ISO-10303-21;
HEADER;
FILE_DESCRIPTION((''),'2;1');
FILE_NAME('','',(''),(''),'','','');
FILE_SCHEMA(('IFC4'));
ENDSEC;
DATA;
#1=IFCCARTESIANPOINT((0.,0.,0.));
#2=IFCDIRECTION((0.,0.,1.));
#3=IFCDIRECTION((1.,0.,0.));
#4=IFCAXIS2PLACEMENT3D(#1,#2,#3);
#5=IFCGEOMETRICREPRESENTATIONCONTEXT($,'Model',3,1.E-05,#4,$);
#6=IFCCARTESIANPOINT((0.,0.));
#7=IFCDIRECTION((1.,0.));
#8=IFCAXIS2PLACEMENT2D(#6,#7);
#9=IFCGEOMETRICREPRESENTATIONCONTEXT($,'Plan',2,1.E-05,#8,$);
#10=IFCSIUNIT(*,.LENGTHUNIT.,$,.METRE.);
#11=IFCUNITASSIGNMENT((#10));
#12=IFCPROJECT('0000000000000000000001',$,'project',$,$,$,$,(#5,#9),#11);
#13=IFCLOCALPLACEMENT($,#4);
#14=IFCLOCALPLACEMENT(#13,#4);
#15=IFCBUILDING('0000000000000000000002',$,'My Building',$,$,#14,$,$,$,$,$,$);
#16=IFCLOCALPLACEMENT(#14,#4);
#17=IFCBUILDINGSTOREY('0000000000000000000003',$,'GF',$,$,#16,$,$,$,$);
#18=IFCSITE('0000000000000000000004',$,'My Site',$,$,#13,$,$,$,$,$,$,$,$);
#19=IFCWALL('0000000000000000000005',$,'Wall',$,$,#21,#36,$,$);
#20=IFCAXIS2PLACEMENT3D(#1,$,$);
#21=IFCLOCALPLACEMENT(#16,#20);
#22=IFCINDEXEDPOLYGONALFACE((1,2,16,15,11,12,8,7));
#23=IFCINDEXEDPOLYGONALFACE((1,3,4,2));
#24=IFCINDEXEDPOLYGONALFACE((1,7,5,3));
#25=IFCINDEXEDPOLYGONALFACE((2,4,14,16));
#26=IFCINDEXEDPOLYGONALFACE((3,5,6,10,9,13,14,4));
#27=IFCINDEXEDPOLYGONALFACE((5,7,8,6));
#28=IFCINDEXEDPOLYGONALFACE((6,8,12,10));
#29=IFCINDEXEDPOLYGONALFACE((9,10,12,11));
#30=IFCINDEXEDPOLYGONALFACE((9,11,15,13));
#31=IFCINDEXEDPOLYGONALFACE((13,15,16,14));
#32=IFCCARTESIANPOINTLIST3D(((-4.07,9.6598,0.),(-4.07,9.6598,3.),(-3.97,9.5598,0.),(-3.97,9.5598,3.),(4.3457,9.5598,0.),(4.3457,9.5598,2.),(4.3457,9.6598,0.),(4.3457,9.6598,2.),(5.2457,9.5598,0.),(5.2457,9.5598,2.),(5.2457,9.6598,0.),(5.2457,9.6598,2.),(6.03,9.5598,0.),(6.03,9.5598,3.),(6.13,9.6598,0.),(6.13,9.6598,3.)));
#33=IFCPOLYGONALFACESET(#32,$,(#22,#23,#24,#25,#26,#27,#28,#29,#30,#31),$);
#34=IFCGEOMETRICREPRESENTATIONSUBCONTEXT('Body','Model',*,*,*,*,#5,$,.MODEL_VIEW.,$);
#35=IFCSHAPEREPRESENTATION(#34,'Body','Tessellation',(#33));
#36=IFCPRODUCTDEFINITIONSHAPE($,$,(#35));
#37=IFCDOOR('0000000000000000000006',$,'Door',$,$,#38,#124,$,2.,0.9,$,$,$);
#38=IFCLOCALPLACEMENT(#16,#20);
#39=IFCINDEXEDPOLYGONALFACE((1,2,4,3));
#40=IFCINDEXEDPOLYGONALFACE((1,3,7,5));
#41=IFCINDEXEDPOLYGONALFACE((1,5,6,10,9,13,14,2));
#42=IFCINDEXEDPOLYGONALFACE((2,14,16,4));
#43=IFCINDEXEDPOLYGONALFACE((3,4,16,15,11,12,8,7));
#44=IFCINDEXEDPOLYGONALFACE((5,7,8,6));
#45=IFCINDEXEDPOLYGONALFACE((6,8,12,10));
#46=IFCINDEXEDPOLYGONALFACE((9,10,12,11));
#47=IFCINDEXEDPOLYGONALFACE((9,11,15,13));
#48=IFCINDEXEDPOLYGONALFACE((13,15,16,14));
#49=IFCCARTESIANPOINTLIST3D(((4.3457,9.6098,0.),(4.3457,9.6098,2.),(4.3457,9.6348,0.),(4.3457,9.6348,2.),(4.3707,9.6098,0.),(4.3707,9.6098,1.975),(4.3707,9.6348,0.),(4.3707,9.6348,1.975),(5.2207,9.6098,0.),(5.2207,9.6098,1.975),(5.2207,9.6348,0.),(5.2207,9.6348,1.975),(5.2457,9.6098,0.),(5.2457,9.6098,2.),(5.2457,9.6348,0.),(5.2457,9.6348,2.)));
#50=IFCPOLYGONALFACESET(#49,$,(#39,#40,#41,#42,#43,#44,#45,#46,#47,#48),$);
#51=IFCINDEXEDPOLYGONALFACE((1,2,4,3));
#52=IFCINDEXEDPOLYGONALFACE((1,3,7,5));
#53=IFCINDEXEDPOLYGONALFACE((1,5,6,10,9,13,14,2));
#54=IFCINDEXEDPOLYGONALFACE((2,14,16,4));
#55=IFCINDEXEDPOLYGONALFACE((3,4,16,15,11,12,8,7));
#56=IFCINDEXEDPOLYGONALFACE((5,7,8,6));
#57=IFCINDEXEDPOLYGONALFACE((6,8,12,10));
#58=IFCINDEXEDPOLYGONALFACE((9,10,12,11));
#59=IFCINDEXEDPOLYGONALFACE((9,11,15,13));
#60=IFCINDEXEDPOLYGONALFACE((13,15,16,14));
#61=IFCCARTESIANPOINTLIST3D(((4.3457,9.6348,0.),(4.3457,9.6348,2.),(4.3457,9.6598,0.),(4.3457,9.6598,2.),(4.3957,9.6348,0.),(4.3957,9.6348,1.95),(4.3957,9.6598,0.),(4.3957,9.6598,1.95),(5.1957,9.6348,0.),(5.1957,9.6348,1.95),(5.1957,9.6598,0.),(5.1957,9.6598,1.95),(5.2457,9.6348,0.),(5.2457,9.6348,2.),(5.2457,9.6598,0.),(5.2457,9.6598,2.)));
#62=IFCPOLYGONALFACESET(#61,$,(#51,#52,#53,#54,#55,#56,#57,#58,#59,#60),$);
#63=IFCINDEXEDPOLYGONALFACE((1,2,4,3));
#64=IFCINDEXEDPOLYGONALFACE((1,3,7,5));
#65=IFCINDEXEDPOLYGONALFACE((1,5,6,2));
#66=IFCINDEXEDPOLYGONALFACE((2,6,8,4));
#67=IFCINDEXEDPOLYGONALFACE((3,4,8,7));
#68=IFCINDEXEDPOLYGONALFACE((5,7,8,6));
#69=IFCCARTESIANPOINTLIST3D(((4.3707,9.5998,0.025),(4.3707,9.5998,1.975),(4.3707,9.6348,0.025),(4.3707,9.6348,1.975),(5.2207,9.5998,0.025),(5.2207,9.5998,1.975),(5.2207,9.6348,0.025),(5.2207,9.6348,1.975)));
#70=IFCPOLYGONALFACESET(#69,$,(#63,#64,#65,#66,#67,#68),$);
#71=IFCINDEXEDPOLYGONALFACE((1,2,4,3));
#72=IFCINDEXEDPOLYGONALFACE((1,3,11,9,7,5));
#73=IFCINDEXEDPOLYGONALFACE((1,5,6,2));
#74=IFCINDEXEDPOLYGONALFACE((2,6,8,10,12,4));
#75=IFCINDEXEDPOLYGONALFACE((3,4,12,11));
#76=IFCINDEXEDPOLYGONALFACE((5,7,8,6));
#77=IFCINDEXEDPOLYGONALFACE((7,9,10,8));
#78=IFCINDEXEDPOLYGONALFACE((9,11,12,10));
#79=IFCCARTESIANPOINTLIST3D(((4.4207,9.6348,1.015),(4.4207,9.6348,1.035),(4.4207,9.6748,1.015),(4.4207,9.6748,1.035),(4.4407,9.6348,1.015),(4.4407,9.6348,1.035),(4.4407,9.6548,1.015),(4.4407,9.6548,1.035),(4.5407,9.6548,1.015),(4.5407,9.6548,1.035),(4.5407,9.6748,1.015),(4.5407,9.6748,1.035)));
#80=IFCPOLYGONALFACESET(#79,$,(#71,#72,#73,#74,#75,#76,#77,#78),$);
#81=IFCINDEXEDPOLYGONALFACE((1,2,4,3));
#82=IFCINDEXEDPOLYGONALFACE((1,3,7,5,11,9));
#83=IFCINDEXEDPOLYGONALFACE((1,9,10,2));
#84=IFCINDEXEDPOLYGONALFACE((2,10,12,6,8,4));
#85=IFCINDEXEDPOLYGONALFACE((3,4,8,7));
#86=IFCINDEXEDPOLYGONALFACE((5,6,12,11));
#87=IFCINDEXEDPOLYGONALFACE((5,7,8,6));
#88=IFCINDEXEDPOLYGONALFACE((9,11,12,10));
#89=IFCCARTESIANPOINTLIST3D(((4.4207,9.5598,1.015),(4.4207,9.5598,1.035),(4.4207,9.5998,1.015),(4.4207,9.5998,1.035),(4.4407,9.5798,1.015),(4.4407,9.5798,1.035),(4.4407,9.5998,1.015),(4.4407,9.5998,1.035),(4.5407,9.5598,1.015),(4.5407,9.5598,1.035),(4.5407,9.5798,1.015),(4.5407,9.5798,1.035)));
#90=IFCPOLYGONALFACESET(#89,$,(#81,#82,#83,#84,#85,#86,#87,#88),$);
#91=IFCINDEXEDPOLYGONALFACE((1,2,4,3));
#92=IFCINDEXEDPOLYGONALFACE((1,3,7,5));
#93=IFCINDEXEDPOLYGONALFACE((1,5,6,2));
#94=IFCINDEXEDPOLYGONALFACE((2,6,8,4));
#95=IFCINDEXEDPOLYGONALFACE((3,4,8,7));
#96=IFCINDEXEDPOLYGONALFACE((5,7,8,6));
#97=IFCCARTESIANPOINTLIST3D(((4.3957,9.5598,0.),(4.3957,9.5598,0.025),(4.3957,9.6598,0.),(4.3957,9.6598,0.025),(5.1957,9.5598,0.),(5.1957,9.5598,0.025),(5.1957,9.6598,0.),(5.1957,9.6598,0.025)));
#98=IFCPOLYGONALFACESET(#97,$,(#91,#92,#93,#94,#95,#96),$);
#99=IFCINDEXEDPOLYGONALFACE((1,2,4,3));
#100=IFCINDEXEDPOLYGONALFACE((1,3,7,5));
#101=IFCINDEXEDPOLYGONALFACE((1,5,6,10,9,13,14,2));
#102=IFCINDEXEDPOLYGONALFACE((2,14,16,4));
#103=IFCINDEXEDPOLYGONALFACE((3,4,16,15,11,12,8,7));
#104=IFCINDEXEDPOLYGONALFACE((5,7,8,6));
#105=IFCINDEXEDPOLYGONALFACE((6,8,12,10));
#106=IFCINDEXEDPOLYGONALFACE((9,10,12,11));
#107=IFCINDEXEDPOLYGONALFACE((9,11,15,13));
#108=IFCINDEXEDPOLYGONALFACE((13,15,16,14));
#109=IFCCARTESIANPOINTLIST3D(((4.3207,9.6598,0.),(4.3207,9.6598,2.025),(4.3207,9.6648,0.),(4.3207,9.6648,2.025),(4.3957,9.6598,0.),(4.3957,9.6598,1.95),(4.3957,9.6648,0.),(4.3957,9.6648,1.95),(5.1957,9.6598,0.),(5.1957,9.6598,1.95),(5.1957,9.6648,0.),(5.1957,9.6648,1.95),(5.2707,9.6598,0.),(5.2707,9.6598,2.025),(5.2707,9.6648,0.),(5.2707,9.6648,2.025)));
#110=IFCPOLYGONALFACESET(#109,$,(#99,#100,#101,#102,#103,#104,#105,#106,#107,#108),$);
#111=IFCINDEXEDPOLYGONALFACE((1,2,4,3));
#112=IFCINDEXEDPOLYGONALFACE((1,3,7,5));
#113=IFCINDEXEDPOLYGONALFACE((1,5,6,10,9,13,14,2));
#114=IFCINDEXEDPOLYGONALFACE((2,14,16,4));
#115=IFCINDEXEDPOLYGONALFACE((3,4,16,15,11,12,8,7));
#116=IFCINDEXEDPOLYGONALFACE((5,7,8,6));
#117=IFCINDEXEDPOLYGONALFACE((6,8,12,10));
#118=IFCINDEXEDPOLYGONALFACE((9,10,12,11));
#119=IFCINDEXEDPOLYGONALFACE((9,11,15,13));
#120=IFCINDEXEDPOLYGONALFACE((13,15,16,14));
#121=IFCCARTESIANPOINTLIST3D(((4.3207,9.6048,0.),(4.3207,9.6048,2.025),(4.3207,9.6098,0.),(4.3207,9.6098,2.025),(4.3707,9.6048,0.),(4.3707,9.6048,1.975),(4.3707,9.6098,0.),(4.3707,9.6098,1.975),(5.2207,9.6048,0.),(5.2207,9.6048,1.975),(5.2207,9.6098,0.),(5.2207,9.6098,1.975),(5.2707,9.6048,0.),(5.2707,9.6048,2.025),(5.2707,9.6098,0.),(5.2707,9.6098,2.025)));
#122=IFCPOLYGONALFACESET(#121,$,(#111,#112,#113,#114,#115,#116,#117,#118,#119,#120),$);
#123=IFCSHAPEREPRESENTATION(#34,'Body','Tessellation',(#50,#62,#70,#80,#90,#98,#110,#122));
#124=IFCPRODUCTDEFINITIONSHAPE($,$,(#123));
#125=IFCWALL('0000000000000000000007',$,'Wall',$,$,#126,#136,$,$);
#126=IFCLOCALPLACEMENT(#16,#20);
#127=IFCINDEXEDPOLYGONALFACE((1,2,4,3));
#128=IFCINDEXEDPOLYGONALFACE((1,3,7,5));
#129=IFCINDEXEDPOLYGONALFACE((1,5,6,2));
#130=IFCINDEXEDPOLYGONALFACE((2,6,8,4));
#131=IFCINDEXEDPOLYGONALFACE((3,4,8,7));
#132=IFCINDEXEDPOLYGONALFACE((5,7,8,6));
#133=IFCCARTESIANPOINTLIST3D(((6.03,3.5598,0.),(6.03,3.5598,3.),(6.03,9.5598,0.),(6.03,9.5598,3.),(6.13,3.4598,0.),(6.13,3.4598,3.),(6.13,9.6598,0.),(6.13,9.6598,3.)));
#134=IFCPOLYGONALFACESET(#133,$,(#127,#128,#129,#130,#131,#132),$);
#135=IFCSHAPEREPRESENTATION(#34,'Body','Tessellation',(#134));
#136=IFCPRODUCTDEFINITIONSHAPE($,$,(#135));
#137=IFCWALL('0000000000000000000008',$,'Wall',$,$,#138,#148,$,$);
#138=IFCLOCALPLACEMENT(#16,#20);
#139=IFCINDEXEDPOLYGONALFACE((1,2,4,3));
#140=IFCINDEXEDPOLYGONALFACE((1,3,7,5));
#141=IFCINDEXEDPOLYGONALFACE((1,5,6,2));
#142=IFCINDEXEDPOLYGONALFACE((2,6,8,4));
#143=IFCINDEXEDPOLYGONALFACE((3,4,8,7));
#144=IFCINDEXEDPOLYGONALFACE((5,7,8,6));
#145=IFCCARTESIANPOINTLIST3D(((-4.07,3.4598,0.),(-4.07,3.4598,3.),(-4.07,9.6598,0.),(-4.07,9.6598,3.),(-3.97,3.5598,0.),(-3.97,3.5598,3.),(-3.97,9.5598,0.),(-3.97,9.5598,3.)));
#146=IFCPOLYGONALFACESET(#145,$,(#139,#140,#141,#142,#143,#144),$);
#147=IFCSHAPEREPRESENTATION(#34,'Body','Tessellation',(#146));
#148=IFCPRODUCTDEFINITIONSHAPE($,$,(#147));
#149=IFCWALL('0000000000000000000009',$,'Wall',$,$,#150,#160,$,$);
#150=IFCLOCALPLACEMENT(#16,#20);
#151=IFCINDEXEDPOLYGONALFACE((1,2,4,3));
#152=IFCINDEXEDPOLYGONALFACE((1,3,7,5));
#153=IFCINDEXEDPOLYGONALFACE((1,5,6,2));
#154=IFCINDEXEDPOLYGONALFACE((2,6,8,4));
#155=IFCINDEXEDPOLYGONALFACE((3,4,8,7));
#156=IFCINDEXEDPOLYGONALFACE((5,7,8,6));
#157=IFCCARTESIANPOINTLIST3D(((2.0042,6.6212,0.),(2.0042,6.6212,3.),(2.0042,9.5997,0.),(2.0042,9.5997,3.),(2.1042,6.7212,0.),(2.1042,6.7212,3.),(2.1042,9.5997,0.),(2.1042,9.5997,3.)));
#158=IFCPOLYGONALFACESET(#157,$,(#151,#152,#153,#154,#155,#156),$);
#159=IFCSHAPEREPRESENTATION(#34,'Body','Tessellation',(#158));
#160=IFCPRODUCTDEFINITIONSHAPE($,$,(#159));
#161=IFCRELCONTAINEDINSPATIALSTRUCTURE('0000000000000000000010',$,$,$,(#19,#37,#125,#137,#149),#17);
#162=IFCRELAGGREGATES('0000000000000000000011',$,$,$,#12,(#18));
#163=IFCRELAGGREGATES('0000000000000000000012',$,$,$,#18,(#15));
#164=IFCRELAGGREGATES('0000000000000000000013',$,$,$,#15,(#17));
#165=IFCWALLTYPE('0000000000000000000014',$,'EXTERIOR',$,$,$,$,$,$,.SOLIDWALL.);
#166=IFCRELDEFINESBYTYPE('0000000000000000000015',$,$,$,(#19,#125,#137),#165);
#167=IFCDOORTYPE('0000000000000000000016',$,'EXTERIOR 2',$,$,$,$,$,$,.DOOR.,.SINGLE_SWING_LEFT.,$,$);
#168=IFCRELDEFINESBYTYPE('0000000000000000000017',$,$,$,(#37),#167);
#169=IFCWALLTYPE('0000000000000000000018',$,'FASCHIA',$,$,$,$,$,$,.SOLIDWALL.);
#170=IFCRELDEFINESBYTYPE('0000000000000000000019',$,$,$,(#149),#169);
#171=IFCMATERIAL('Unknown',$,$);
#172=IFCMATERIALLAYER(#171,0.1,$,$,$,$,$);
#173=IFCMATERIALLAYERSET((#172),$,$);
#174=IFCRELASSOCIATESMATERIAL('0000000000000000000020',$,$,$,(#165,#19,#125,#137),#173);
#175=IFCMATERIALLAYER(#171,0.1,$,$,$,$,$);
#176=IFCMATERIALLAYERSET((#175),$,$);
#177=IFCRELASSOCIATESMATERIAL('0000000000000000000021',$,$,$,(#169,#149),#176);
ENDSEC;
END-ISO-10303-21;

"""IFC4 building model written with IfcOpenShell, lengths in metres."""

from ifc_helpers import new_model, entity, si_unit, frame, origin_with_axes, origin_2d_with_axis, place, context, subcontext, project, spatial, line, indexed_curve, outline, extrude, shape, source, transform, mapped, material, layer, layer_set, layer_usage, type_object, type_shapes, element, fill, save


model = new_model("IFC4")

# Units and contexts
model_context = context("Model", 3, precision=1e-05, world=origin_with_axes())
plan_context = context("Plan", 2, precision=1e-05, world=origin_2d_with_axis())
body_context_1 = subcontext(model_context, "Body", "Model", "MODEL_VIEW")
body_context_2 = subcontext(plan_context, "Body", "Plan", "PLAN_VIEW")
ifc_project = project(units=[si_unit("LENGTHUNIT", "METRE")], contexts=[model_context, plan_context])

# Site, building, storey
site_placement = place(None, origin_with_axes())
site = spatial("IfcSite", under=ifc_project, at=site_placement, Name="My Site")
building_placement = place(site_placement, origin_with_axes())
building = spatial("IfcBuilding", under=site, at=building_placement, Name="My Building")
storey_placement = place(building_placement, origin_with_axes())
storey = spatial("IfcBuildingStorey", under=building, at=storey_placement, Name="GF")

# Shared definitions
ifc_material = material(Name="Unknown")

# Wall, opening, door
ifc_layer_1 = layer(ifc_material, 0.1)
ifc_layer_set_1 = layer_set([ifc_layer_1])
ifc_layer_usage_1 = layer_usage(ifc_layer_set_1, "AXIS2", "POSITIVE", 0.0)
wall_type_1 = type_object("IfcWallType", Name="EXTERIOR", PredefinedType="SOLIDWALL", material=ifc_layer_set_1)
wall_1_placement = place(storey_placement, frame((-3.97, 9.5598, 0.0), z_axis=(0.0, 0.0, 1.0), x_axis=(1.0, 0.0, 0.0)))
wall_1 = element("IfcWall", 1, at=wall_1_placement, inside=storey, type_object=wall_type_1, material=ifc_layer_usage_1, Name="Wall", context=body_context_1, shape_type="SweptSolid", body=[
    extrude(outline(indexed_curve([(0.0, 0.0), (-0.1, 0.1), (10.1, 0.1), (10.0, 0.0)], segments=[line(1, 2, 3, 4, 1)])), origin_with_axes(), (0.0, 0.0, 1.0), 3.0),
])
shared_shape_1 = source(origin_with_axes(), body_context_1, "Body", "SweptSolid", [
    extrude(outline(indexed_curve([(0.0, 0.0), (0.9, 0.0), (0.9, 2.0), (0.0, 2.0)], segments=[line(1, 2, 3, 4, 1)])), frame((0.0, -0.6, 0.0), z_axis=(0.0, -1.0, 0.0), x_axis=(1.0, 0.0, 0.0)), (0.0, 0.0, -1.0), 1.2),
])
opening_1_placement = place(wall_1_placement, frame((9.2157, 0.1, 0.0), z_axis=(0.0, 0.0, 1.0), x_axis=(-1.0, 0.0, 0.0)))
opening_1 = element("IfcOpeningElement", 2, at=opening_1_placement, cuts=wall_1, PredefinedType="OPENING", context=body_context_1, shape_type="MappedRepresentation", body=[
    mapped(shared_shape_1, transform((0.0, 0.0, 0.0), x_axis=(1.0, 0.0, 0.0), y_axis=(0.0, 1.0, 0.0), z_axis=(0.0, 0.0, 1.0), scale=1.0)),
])
door_type_1 = type_object("IfcDoorType", Name="EXTERIOR 2", OperationType="SINGLE_SWING_LEFT", PredefinedType="DOOR")
shared_shape_2 = source(origin_with_axes(), body_context_1, "Body", "SweptSolid", [
    extrude(outline(indexed_curve([(0.0, 0.0), (0.0, 2.0), (0.9, 2.0), (0.9, 0.0), (0.875, 0.0), (0.875, 1.975), (0.025, 1.975), (0.025, 0.0)], segments=[line(1, 2, 3, 4, 5, 6, 7, 8, 1)])), frame((0.0, 0.025, 0.0), z_axis=(0.0, -1.0, 0.0), x_axis=(1.0, 0.0, 0.0)), (0.0, 0.0, -1.0), 0.025),
    extrude(outline(indexed_curve([(0.0, 0.0), (0.0, 2.0), (0.9, 2.0), (0.9, 0.0), (0.85, 0.0), (0.85, 1.95), (0.05, 1.95), (0.05, 0.0)], segments=[line(1, 2, 3, 4, 5, 6, 7, 8, 1)])), frame((0.0, 0.0, 0.0), z_axis=(0.0, -1.0, 0.0), x_axis=(1.0, 0.0, 0.0)), (0.0, 0.0, -1.0), 0.025),
    extrude(outline(indexed_curve([(0.0, 0.0), (0.85, 0.0), (0.85, 0.035), (0.0, 0.035)], segments=[line(1, 2, 3, 4, 1)])), frame((0.025, 0.025, 0.025), z_axis=(0.0, 0.0, 1.0), x_axis=(1.0, 0.0, 0.0)), (0.0, 0.0, 1.0), 1.95),
    extrude(outline(indexed_curve([(0.0, 0.0), (0.0, -0.04), (-0.12, -0.04), (-0.12, -0.02), (-0.02, -0.02), (-0.02, 0.0)], segments=[line(1, 2, 3, 4, 5, 6, 1)])), frame((0.825, 0.025, 1.015), z_axis=(0.0, 0.0, 1.0), x_axis=(1.0, 0.0, 0.0)), (0.0, 0.0, 1.0), 0.02),
    extrude(outline(indexed_curve([(0.0, 0.0), (0.0, 0.04), (-0.12, 0.04), (-0.12, 0.02), (-0.02, 0.02), (-0.02, 0.0)], segments=[line(1, 2, 3, 4, 5, 6, 1)])), frame((0.825, 0.06, 1.015), z_axis=(0.0, 0.0, 1.0), x_axis=(1.0, 0.0, 0.0)), (0.0, 0.0, 1.0), 0.02),
    extrude(outline(indexed_curve([(0.0, 0.0), (0.8, 0.0), (0.8, 0.1), (0.0, 0.1)], segments=[line(1, 2, 3, 4, 1)])), frame((0.05, 0.0, 0.0), z_axis=(0.0, 0.0, 1.0), x_axis=(1.0, 0.0, 0.0)), (0.0, 0.0, 1.0), 0.025),
    extrude(outline(indexed_curve([(0.0, 0.0), (0.0, 2.025), (0.95, 2.025), (0.95, 0.0), (0.875, 0.0), (0.875, 1.95), (0.075, 1.95), (0.075, 0.0)], segments=[line(1, 2, 3, 4, 5, 6, 7, 8, 1)])), frame((-0.025, -0.005, 0.0), z_axis=(0.0, -1.0, 0.0), x_axis=(1.0, 0.0, 0.0)), (0.0, 0.0, -1.0), 0.005),
    extrude(outline(indexed_curve([(0.0, 0.0), (0.0, 2.025), (0.95, 2.025), (0.95, 0.0), (0.9, 0.0), (0.9, 1.975), (0.05, 1.975), (0.05, 0.0)], segments=[line(1, 2, 3, 4, 5, 6, 7, 8, 1)])), frame((-0.025, 0.05, 0.0), z_axis=(0.0, -1.0, 0.0), x_axis=(1.0, 0.0, 0.0)), (0.0, 0.0, -1.0), 0.005),
])
shared_shape_3 = source(origin_with_axes(), body_context_2, "Body", "Curve2D", [
    entity("IfcIndexedPolyCurve", entity("IfcCartesianPointList2D", [[0.0, 0.0], [0.0, 0.05], [0.025, 0.05], [0.025, 0.025], [0.05, 0.025], [0.05, 0.0]]), [entity("IfcLineIndex", [1, 2, 3, 4, 5, 6, 1])]),
    entity("IfcIndexedPolyCurve", entity("IfcCartesianPointList2D", [[0.9, 0.0], [0.9, 0.05], [0.875, 0.05], [0.875, 0.025], [0.85, 0.025], [0.85, 0.0]]), [entity("IfcLineIndex", [1, 2, 3, 4, 5, 6, 1])]),
    entity("IfcTrimmedCurve", entity("IfcEllipse", entity("IfcAxis2Placement2D", entity("IfcCartesianPoint", [0.06, 0.05]), entity("IfcDirection", [1.0, 0.0])), 0.815, 0.85), [entity("IfcCartesianPoint", [0.875, 0.05])], [entity("IfcCartesianPoint", [0.06, 0.9])], True, "CARTESIAN"),
    entity("IfcIndexedPolyCurve", entity("IfcCartesianPointList2D", [[0.025, 0.05], [0.06, 0.05], [0.06, 0.9], [0.025, 0.9]]), [entity("IfcLineIndex", [1, 2, 3, 4, 1])]),
])
type_shapes(door_type_1, [shared_shape_2, shared_shape_3])
door_1_placement = place(opening_1_placement, frame((0.0, 0.0, 0.0), z_axis=(0.0, 0.0, 1.0), x_axis=(1.0, 0.0, 0.0)))
door_1 = element("IfcDoor", 3, at=door_1_placement, inside=storey, type_object=door_type_1, Name="Door", OverallHeight=2.0, OverallWidth=0.9, shapes=[
    shape(body_context_1, "Body", "MappedRepresentation", [mapped(shared_shape_2, transform((0.0, 0.0, 0.0), x_axis=(1.0, 0.0, 0.0), y_axis=(0.0, 1.0, 0.0), z_axis=(0.0, 0.0, 1.0), scale=1.0))]),
    shape(body_context_2, "Body", "MappedRepresentation", [mapped(shared_shape_3, transform((0.0, 0.0, 0.0), x_axis=(1.0, 0.0, 0.0), y_axis=(0.0, 1.0, 0.0), z_axis=(0.0, 0.0, 1.0), scale=1.0))]),
])
fill(opening_1, door_1)

# Wall
ifc_layer_usage_2 = layer_usage(ifc_layer_set_1, "AXIS2", "POSITIVE", 0.0)
wall_2_placement = place(storey_placement, frame((6.03, 9.5598, 0.0), z_axis=(0.0, 0.0, 1.0), x_axis=(0.0, -1.0, 0.0)))
element("IfcWall", 4, at=wall_2_placement, inside=storey, type_object=wall_type_1, material=ifc_layer_usage_2, Name="Wall", context=body_context_1, shape_type="SweptSolid", body=[
    extrude(outline(indexed_curve([(0.0, 0.0), (-0.1, 0.1), (6.1, 0.1), (6.0, 0.0)], segments=[line(1, 2, 3, 4, 1)])), origin_with_axes(), (0.0, 0.0, 1.0), 3.0),
])

# Walls
ifc_layer_usage_3 = layer_usage(ifc_layer_set_1, "AXIS2", "POSITIVE", 0.0)
wall_3_placement = place(storey_placement, frame((-3.97, 3.5598, 0.0), z_axis=(0.0, 0.0, 1.0), x_axis=(0.0, 1.0, 0.0)))
element("IfcWall", 5, at=wall_3_placement, inside=storey, type_object=wall_type_1, material=ifc_layer_usage_3, Name="Wall", context=body_context_1, shape_type="SweptSolid", body=[
    extrude(outline(indexed_curve([(0.0, 0.0), (-0.1, 0.1), (6.1, 0.1), (6.0, 0.0)], segments=[line(1, 2, 3, 4, 1)])), origin_with_axes(), (0.0, 0.0, 1.0), 3.0),
])
ifc_layer_2 = layer(ifc_material, 0.1)
ifc_layer_set_2 = layer_set([ifc_layer_2])
ifc_layer_usage_4 = layer_usage(ifc_layer_set_2, "AXIS2", "POSITIVE", 0.0)
wall_type_2 = type_object("IfcWallType", Name="FASCHIA", PredefinedType="SOLIDWALL", material=ifc_layer_set_2)
wall_4_placement = place(storey_placement, frame((2.0042, 9.5997, 0.0), z_axis=(0.0, 0.0, 1.0), x_axis=(0.0, -1.0, 0.0)))
element("IfcWall", 6, at=wall_4_placement, inside=storey, type_object=wall_type_2, material=ifc_layer_usage_4, Name="Wall", context=body_context_1, shape_type="SweptSolid", body=[
    extrude(outline(indexed_curve([(0.0, 0.0), (0.0, 0.1), (2.8784, 0.1), (2.9784, 0.0)], segments=[line(1, 2, 3, 4, 1)])), origin_with_axes(), (0.0, 0.0, 1.0), 3.0),
])

save(model, "model.ifc")
